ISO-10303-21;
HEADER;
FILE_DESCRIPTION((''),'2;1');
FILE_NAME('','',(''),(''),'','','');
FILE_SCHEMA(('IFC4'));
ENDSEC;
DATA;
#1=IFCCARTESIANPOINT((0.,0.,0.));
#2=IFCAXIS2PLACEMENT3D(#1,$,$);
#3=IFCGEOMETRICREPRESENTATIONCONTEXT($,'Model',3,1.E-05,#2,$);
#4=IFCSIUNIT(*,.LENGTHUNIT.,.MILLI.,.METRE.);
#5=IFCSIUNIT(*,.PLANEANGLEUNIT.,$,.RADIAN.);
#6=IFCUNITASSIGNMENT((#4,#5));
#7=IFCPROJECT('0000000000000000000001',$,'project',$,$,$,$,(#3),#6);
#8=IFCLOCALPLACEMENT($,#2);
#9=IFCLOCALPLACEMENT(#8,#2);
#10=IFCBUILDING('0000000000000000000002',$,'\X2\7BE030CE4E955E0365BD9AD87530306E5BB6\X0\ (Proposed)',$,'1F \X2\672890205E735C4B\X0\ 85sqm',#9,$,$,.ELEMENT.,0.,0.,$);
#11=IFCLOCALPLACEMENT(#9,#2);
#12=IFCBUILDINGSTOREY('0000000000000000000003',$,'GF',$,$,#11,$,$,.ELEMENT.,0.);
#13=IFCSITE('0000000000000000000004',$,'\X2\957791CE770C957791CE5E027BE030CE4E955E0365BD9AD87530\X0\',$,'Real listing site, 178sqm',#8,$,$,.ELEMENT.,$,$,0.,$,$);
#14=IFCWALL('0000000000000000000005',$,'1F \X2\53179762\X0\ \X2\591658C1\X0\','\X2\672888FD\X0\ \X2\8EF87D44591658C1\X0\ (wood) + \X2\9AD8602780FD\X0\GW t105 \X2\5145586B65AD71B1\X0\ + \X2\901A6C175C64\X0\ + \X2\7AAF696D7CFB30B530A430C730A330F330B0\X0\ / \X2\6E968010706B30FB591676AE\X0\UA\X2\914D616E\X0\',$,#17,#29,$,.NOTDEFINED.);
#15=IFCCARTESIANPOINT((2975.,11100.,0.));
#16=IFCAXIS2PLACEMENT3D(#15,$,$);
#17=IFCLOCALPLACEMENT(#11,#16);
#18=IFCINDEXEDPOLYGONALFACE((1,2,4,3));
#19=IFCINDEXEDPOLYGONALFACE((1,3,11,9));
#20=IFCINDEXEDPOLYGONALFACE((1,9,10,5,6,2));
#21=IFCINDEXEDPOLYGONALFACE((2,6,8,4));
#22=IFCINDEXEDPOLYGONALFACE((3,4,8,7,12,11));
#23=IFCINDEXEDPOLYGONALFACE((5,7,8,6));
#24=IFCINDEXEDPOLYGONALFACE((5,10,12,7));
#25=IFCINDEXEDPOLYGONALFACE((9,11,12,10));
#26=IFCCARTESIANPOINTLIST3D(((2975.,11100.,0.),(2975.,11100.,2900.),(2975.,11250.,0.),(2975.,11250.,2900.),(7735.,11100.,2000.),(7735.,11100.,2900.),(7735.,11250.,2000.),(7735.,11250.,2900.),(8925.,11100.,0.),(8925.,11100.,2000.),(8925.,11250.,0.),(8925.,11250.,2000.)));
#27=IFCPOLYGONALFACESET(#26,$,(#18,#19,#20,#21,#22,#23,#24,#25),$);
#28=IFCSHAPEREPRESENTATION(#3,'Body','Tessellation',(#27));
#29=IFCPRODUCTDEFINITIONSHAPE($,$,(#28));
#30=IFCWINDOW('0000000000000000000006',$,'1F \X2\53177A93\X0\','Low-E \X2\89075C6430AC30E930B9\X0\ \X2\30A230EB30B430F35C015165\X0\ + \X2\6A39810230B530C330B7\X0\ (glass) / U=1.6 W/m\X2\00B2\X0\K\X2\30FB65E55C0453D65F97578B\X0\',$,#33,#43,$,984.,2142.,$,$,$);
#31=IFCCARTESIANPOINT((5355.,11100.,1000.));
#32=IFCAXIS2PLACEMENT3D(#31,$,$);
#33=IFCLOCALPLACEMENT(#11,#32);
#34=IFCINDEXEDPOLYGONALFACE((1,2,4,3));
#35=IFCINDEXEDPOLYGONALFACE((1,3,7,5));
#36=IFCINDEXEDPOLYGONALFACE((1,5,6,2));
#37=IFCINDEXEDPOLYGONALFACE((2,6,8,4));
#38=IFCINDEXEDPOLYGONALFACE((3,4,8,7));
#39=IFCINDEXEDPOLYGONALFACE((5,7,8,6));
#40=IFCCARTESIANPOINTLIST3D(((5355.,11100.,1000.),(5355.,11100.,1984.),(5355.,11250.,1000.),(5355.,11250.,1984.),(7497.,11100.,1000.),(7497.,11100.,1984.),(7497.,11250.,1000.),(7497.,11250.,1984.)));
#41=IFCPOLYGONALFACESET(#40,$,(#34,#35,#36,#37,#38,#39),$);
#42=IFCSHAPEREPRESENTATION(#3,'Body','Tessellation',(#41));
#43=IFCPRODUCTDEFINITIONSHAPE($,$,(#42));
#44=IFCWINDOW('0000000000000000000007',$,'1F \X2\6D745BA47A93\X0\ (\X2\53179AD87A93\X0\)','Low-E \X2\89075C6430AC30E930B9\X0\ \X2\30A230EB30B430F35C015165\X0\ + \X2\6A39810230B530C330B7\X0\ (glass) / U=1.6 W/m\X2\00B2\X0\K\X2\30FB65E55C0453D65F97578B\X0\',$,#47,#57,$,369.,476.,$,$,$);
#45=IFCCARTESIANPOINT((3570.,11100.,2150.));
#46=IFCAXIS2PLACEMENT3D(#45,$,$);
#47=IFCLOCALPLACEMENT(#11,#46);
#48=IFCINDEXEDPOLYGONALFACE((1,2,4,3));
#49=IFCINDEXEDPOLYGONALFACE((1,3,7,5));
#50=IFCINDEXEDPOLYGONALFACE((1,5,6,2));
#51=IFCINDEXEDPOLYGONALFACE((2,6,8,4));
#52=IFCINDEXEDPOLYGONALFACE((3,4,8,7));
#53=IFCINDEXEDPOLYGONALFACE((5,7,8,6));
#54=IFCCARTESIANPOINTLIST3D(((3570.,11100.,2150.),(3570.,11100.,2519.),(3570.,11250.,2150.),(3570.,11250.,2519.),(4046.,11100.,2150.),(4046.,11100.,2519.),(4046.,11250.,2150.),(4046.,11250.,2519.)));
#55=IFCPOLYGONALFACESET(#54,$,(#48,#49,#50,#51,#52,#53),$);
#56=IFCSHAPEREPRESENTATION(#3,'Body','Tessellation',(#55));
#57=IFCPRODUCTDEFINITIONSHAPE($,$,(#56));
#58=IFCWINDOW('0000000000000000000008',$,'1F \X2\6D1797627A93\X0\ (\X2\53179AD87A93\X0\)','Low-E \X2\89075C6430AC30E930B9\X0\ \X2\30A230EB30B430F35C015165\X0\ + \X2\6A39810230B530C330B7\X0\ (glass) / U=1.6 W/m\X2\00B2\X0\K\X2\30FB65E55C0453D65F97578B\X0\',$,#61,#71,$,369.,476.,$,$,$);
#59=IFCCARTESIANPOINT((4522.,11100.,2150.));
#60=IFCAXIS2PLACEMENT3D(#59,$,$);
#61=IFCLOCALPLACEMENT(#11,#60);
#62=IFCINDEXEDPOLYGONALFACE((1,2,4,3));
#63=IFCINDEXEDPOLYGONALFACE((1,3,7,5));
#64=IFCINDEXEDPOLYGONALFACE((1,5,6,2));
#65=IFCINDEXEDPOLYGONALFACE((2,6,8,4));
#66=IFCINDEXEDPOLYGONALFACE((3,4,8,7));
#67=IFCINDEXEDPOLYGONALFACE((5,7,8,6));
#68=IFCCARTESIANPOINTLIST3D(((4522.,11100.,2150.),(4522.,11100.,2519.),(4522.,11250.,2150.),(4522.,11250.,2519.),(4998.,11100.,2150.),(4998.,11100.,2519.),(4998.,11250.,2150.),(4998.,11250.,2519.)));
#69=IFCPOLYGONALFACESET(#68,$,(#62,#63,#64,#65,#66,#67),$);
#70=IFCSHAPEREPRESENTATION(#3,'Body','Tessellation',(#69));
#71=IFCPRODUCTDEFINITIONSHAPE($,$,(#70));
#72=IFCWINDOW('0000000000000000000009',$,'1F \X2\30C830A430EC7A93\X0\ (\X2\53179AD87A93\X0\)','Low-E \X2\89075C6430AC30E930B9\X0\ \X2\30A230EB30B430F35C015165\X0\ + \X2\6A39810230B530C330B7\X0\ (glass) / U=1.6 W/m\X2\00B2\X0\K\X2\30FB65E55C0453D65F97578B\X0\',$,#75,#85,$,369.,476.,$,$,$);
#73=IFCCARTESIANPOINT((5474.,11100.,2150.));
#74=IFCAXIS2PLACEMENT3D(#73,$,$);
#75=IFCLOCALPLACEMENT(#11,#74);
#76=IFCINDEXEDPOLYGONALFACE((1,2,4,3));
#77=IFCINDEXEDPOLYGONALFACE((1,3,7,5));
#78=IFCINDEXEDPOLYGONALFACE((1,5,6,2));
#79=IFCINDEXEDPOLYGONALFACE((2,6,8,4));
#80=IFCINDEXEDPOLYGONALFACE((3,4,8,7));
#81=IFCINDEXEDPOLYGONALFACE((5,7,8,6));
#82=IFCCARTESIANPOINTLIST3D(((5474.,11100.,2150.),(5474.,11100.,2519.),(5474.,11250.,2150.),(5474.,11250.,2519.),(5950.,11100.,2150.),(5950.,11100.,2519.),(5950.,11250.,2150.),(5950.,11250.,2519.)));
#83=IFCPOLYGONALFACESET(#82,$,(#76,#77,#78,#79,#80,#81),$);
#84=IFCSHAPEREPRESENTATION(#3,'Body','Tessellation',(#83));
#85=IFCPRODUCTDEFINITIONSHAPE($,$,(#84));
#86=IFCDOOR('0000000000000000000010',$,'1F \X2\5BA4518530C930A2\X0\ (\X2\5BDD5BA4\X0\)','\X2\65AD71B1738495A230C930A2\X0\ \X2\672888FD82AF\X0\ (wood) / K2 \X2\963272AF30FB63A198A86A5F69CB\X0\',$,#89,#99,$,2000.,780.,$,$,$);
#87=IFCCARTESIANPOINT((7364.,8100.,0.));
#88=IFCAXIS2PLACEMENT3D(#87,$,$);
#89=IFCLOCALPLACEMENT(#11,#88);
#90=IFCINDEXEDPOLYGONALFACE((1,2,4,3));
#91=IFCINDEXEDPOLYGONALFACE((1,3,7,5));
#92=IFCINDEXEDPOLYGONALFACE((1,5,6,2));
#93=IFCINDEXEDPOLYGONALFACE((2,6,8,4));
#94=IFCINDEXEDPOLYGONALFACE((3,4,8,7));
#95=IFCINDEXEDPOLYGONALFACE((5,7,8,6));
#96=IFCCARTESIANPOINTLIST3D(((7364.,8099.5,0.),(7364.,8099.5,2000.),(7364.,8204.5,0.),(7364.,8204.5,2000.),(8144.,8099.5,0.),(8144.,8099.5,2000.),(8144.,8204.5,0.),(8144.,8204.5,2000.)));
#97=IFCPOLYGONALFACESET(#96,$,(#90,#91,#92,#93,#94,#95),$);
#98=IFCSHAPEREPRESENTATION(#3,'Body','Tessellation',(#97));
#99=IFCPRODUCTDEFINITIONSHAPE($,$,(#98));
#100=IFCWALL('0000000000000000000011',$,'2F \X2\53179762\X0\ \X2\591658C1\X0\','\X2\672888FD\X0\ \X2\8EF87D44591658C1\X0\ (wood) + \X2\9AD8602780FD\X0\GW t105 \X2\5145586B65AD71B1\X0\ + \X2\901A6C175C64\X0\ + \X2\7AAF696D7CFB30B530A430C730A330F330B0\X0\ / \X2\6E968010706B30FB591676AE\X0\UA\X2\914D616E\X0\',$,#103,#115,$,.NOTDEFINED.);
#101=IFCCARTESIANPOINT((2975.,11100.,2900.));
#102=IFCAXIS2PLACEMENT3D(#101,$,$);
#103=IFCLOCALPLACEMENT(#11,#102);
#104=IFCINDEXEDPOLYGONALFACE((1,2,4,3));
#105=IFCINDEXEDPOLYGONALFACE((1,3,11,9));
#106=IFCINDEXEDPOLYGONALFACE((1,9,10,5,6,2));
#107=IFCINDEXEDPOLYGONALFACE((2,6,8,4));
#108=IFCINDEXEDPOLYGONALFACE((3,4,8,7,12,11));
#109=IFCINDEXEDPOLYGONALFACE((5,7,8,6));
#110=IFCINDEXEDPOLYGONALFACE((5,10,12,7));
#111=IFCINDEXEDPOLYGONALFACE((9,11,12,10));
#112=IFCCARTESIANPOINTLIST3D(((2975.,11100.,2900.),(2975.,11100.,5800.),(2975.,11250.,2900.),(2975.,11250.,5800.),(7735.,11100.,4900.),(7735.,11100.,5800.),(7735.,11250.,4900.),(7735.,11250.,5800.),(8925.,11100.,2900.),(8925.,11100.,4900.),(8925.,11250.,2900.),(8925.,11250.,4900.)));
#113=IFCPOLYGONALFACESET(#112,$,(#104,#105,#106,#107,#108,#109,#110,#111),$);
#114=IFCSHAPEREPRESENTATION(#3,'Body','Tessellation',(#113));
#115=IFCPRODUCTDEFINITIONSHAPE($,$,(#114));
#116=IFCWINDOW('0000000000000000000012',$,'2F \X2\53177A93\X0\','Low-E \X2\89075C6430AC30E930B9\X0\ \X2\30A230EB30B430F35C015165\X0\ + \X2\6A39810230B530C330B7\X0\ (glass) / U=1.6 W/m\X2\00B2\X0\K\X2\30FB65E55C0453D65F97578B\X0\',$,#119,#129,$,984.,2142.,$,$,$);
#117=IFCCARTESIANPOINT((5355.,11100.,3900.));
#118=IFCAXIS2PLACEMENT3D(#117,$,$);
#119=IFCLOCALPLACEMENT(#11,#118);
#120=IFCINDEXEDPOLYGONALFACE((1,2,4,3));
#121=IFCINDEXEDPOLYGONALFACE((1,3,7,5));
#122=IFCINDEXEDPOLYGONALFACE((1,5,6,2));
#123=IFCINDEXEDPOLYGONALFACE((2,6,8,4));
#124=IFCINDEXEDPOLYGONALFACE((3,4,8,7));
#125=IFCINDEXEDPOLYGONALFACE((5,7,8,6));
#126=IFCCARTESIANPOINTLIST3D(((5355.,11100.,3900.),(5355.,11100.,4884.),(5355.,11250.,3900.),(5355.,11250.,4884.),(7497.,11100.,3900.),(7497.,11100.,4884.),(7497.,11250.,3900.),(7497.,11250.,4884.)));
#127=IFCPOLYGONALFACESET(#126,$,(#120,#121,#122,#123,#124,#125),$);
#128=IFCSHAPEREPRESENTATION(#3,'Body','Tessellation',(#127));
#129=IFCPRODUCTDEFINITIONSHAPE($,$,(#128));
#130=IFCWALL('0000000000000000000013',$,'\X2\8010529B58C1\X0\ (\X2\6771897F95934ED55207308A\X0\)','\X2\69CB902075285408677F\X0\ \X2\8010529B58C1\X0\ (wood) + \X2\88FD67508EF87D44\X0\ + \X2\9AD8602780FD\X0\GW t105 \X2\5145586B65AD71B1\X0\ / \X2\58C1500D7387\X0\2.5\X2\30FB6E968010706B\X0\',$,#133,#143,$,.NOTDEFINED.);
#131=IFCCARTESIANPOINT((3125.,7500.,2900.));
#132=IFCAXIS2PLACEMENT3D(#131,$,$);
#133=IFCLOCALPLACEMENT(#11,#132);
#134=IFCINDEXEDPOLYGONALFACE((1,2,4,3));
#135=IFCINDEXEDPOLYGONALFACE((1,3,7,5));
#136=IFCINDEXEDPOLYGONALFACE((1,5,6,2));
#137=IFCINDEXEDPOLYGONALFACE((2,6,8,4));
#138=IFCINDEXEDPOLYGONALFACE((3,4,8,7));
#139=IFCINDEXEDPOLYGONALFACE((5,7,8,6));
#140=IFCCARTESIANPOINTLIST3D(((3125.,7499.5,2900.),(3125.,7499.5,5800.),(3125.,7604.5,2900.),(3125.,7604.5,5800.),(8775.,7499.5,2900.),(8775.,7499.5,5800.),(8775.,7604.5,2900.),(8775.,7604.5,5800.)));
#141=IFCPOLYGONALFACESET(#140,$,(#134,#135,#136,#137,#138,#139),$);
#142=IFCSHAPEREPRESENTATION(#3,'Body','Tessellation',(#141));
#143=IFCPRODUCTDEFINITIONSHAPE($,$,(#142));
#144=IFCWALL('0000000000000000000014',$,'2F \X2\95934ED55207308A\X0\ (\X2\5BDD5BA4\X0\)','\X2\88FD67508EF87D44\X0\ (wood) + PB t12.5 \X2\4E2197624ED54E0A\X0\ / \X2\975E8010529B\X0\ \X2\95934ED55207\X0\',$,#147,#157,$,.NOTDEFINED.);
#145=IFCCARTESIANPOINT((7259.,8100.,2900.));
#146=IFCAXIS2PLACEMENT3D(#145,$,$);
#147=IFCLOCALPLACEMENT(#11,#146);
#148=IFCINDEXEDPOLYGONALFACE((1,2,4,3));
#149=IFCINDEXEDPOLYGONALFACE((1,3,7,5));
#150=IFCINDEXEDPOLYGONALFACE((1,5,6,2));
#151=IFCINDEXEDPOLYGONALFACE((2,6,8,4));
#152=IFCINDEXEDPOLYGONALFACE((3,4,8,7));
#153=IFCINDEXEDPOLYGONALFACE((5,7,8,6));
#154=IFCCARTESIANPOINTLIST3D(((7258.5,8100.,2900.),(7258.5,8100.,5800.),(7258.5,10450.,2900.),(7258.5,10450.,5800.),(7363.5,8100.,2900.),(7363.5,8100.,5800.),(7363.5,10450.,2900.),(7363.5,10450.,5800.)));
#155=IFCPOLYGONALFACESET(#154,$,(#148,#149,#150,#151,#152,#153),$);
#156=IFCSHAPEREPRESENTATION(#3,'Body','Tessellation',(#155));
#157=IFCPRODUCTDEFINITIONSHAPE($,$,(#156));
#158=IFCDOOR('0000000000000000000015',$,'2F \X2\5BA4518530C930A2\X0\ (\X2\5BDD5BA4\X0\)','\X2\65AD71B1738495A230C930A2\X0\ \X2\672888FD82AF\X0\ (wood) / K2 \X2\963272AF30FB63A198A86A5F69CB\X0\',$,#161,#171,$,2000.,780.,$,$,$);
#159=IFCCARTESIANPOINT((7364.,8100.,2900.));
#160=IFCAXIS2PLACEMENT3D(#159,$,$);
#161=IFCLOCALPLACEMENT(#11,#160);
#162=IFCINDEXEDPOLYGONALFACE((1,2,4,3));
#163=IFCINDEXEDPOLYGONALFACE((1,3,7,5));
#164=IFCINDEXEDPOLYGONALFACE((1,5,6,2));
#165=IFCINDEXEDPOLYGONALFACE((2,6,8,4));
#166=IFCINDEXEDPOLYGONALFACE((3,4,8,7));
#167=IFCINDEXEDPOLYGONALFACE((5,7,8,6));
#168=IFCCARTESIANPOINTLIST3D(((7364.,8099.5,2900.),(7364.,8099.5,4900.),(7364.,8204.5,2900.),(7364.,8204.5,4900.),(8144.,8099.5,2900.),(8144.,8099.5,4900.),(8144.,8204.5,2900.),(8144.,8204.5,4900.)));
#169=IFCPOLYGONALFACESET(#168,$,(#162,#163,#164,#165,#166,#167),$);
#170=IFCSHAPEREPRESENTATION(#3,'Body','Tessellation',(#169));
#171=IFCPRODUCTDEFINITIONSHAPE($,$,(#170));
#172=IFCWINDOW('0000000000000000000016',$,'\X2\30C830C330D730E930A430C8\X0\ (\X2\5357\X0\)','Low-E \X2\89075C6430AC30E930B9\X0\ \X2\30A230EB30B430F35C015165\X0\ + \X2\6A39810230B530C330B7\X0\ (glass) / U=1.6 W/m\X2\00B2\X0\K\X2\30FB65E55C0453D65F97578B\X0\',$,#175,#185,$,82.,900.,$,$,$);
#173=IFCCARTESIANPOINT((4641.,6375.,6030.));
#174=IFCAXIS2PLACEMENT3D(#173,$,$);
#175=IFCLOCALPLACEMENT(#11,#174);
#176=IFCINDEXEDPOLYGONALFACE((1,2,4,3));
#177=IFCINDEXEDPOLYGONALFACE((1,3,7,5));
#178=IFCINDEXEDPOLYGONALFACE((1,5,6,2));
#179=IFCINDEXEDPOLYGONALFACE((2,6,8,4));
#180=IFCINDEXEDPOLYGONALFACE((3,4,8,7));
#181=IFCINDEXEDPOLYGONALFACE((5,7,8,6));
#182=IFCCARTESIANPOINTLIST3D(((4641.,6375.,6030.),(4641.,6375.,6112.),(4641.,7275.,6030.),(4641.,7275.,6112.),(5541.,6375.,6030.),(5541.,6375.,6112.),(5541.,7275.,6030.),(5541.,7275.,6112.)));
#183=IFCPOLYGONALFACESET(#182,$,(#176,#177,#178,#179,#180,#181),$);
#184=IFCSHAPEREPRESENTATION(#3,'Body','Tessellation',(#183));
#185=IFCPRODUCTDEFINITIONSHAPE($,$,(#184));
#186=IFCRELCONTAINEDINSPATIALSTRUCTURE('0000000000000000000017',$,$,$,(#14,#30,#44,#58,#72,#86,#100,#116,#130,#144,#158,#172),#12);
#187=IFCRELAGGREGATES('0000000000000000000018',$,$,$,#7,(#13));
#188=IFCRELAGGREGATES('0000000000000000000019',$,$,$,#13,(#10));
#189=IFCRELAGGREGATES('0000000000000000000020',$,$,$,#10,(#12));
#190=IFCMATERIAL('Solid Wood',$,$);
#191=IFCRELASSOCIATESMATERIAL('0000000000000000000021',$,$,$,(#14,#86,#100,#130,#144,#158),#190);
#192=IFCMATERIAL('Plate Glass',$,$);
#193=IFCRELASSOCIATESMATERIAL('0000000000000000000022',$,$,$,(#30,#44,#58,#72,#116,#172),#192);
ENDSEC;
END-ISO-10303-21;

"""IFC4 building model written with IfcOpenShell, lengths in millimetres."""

from ifc_helpers import new_model, si_unit, frame, frame_2d, origin, place, context, project, spatial, rectangle, extrude, material, element, fill, save


model = new_model("IFC4")

# Units and contexts
model_context = context("Model", 3, precision=1e-05, world=origin())
ifc_project = project(units=[si_unit("LENGTHUNIT", "METRE", prefix="MILLI"), si_unit("PLANEANGLEUNIT", "RADIAN")], contexts=[model_context])

# Site, building, storey
site_placement = place(None, origin())
site = spatial("IfcSite", under=ifc_project, at=site_placement, Name="長野県長野市篠ノ井布施高田", ObjectType="Real listing site, 178sqm", CompositionType="ELEMENT", RefElevation=0.0)
building_placement = place(site_placement, origin())
building = spatial("IfcBuilding", under=site, at=building_placement, Name="篠ノ井布施高田の家 (Proposed)", ObjectType="1F 木造平屋 85sqm", CompositionType="ELEMENT", ElevationOfRefHeight=0.0, ElevationOfTerrain=0.0)
storey_placement = place(building_placement, origin())
storey = spatial("IfcBuildingStorey", under=building, at=storey_placement, Name="GF", CompositionType="ELEMENT", Elevation=0.0)

# Wall, openings, windows
ifc_material_1 = material(Name="Solid Wood")
wall_1_placement = place(storey_placement, frame((2975.0, 11100.0, 0.0)))
wall_1 = element("IfcWall", 1, at=wall_1_placement, inside=storey, material=ifc_material_1, Name="1F 北面 外壁", Description="木製 軸組外壁 (wood) + 高性能GW t105 充填断熱 + 通気層 + 窯業系サイディング / 準耐火・外皮UA配慮", PredefinedType="NOTDEFINED", context=model_context, shape_type="SweptSolid", body=[
    extrude(rectangle(XDim=5950.0, YDim=150.0, at=frame_2d((2975.0, 75.0))), frame((2975.0, 11100.0, 0.0)), (0.0, 0.0, 1.0), 2900.0),
])
opening_1_placement = place(storey_placement, frame((5355.0, 11100.0, 1000.0)))
opening_1 = element("IfcOpeningElement", 2, at=opening_1_placement, cuts=wall_1, PredefinedType="NOTDEFINED", context=model_context, shape_type="SweptSolid", body=[
    extrude(rectangle(XDim=2142.0, YDim=150.0, at=frame_2d((1071.0, 75.0))), frame((5355.0, 11100.0, 1000.0)), (0.0, 0.0, 1.0), 984.0),
])
opening_2_placement = place(storey_placement, frame((3570.0, 11100.0, 2150.0)))
opening_2 = element("IfcOpeningElement", 3, at=opening_2_placement, cuts=wall_1, PredefinedType="NOTDEFINED", context=model_context, shape_type="SweptSolid", body=[
    extrude(rectangle(XDim=476.0, YDim=150.0, at=frame_2d((238.0, 75.0))), frame((3570.0, 11100.0, 2150.0)), (0.0, 0.0, 1.0), 369.0),
])
opening_3_placement = place(storey_placement, frame((4522.0, 11100.0, 2150.0)))
opening_3 = element("IfcOpeningElement", 4, at=opening_3_placement, cuts=wall_1, PredefinedType="NOTDEFINED", context=model_context, shape_type="SweptSolid", body=[
    extrude(rectangle(XDim=476.0, YDim=150.0, at=frame_2d((238.0, 75.0))), frame((4522.0, 11100.0, 2150.0)), (0.0, 0.0, 1.0), 369.0),
])
opening_4_placement = place(storey_placement, frame((5474.0, 11100.0, 2150.0)))
opening_4 = element("IfcOpeningElement", 5, at=opening_4_placement, cuts=wall_1, PredefinedType="NOTDEFINED", context=model_context, shape_type="SweptSolid", body=[
    extrude(rectangle(XDim=476.0, YDim=150.0, at=frame_2d((238.0, 75.0))), frame((5474.0, 11100.0, 2150.0)), (0.0, 0.0, 1.0), 369.0),
])
ifc_material_2 = material(Name="Plate Glass")
window_1_placement = place(storey_placement, frame((5355.0, 11100.0, 1000.0)))
window_1 = element("IfcWindow", 6, at=window_1_placement, inside=storey, material=ifc_material_2, Name="1F 北窓", Description="Low-E 複層ガラス アルゴン封入 + 樹脂サッシ (glass) / U=1.6 W/m²K・日射取得型", OverallHeight=984.0, OverallWidth=2142.0, context=model_context, shape_type="SweptSolid", body=[
    extrude(rectangle(XDim=2142.0, YDim=150.0, at=frame_2d((1071.0, 75.0))), frame((5355.0, 11100.0, 1000.0)), (0.0, 0.0, 1.0), 984.0),
])
fill(opening_1, window_1)
window_2_placement = place(storey_placement, frame((3570.0, 11100.0, 2150.0)))
window_2 = element("IfcWindow", 7, at=window_2_placement, inside=storey, material=ifc_material_2, Name="1F 浴室窓 (北高窓)", Description="Low-E 複層ガラス アルゴン封入 + 樹脂サッシ (glass) / U=1.6 W/m²K・日射取得型", OverallHeight=369.0, OverallWidth=476.0, context=model_context, shape_type="SweptSolid", body=[
    extrude(rectangle(XDim=476.0, YDim=150.0, at=frame_2d((238.0, 75.0))), frame((3570.0, 11100.0, 2150.0)), (0.0, 0.0, 1.0), 369.0),
])
fill(opening_2, window_2)
window_3_placement = place(storey_placement, frame((4522.0, 11100.0, 2150.0)))
window_3 = element("IfcWindow", 8, at=window_3_placement, inside=storey, material=ifc_material_2, Name="1F 洗面窓 (北高窓)", Description="Low-E 複層ガラス アルゴン封入 + 樹脂サッシ (glass) / U=1.6 W/m²K・日射取得型", OverallHeight=369.0, OverallWidth=476.0, context=model_context, shape_type="SweptSolid", body=[
    extrude(rectangle(XDim=476.0, YDim=150.0, at=frame_2d((238.0, 75.0))), frame((4522.0, 11100.0, 2150.0)), (0.0, 0.0, 1.0), 369.0),
])
fill(opening_3, window_3)
window_4_placement = place(storey_placement, frame((5474.0, 11100.0, 2150.0)))
window_4 = element("IfcWindow", 9, at=window_4_placement, inside=storey, material=ifc_material_2, Name="1F トイレ窓 (北高窓)", Description="Low-E 複層ガラス アルゴン封入 + 樹脂サッシ (glass) / U=1.6 W/m²K・日射取得型", OverallHeight=369.0, OverallWidth=476.0, context=model_context, shape_type="SweptSolid", body=[
    extrude(rectangle(XDim=476.0, YDim=150.0, at=frame_2d((238.0, 75.0))), frame((5474.0, 11100.0, 2150.0)), (0.0, 0.0, 1.0), 369.0),
])
fill(opening_4, window_4)

# Door
door_1_placement = place(storey_placement, frame((7364.0, 8100.0, 0.0)))
element("IfcDoor", 10, at=door_1_placement, inside=storey, material=ifc_material_1, Name="1F 室内ドア (寝室)", Description="断熱玄関ドア 木製芯 (wood) / K2 防犯・採風機構", OverallHeight=2000.0, OverallWidth=780.0, context=model_context, shape_type="SweptSolid", body=[
    extrude(rectangle(XDim=780.0, YDim=105.0, at=frame_2d((390.0, 52.0))), frame((7364.0, 8100.0, 0.0)), (0.0, 0.0, 1.0), 2000.0),
])

# Wall, opening, window
wall_2_placement = place(storey_placement, frame((2975.0, 11100.0, 2900.0)))
wall_2 = element("IfcWall", 11, at=wall_2_placement, inside=storey, material=ifc_material_1, Name="2F 北面 外壁", Description="木製 軸組外壁 (wood) + 高性能GW t105 充填断熱 + 通気層 + 窯業系サイディング / 準耐火・外皮UA配慮", PredefinedType="NOTDEFINED", context=model_context, shape_type="SweptSolid", body=[
    extrude(rectangle(XDim=5950.0, YDim=150.0, at=frame_2d((2975.0, 75.0))), frame((2975.0, 11100.0, 2900.0)), (0.0, 0.0, 1.0), 2900.0),
])
opening_5_placement = place(storey_placement, frame((5355.0, 11100.0, 3900.0)))
opening_5 = element("IfcOpeningElement", 12, at=opening_5_placement, cuts=wall_2, PredefinedType="NOTDEFINED", context=model_context, shape_type="SweptSolid", body=[
    extrude(rectangle(XDim=2142.0, YDim=150.0, at=frame_2d((1071.0, 75.0))), frame((5355.0, 11100.0, 3900.0)), (0.0, 0.0, 1.0), 984.0),
])
window_5_placement = place(storey_placement, frame((5355.0, 11100.0, 3900.0)))
window_5 = element("IfcWindow", 13, at=window_5_placement, inside=storey, material=ifc_material_2, Name="2F 北窓", Description="Low-E 複層ガラス アルゴン封入 + 樹脂サッシ (glass) / U=1.6 W/m²K・日射取得型", OverallHeight=984.0, OverallWidth=2142.0, context=model_context, shape_type="SweptSolid", body=[
    extrude(rectangle(XDim=2142.0, YDim=150.0, at=frame_2d((1071.0, 75.0))), frame((5355.0, 11100.0, 3900.0)), (0.0, 0.0, 1.0), 984.0),
])
fill(opening_5, window_5)

# Walls
wall_3_placement = place(storey_placement, frame((3125.0, 7500.0, 2900.0)))
element("IfcWall", 14, at=wall_3_placement, inside=storey, material=ifc_material_1, Name="耐力壁 (東西間仕切り)", Description="構造用合板 耐力壁 (wood) + 製材軸組 + 高性能GW t105 充填断熱 / 壁倍率2.5・準耐火", PredefinedType="NOTDEFINED", context=model_context, shape_type="SweptSolid", body=[
    extrude(rectangle(XDim=5650.0, YDim=105.0, at=frame_2d((2825.0, 52.0))), frame((3125.0, 7500.0, 2900.0)), (0.0, 0.0, 1.0), 2900.0),
])
wall_4_placement = place(storey_placement, frame((7259.0, 8100.0, 2900.0)))
element("IfcWall", 15, at=wall_4_placement, inside=storey, material=ifc_material_1, Name="2F 間仕切り (寝室)", Description="製材軸組 (wood) + PB t12.5 両面仕上 / 非耐力 間仕切", PredefinedType="NOTDEFINED", context=model_context, shape_type="SweptSolid", body=[
    extrude(rectangle(XDim=105.0, YDim=2350.0, at=frame_2d((52.0, 1175.0))), frame((7259.0, 8100.0, 2900.0)), (0.0, 0.0, 1.0), 2900.0),
])

# Door
door_2_placement = place(storey_placement, frame((7364.0, 8100.0, 2900.0)))
element("IfcDoor", 16, at=door_2_placement, inside=storey, material=ifc_material_1, Name="2F 室内ドア (寝室)", Description="断熱玄関ドア 木製芯 (wood) / K2 防犯・採風機構", OverallHeight=2000.0, OverallWidth=780.0, context=model_context, shape_type="SweptSolid", body=[
    extrude(rectangle(XDim=780.0, YDim=105.0, at=frame_2d((390.0, 52.0))), frame((7364.0, 8100.0, 2900.0)), (0.0, 0.0, 1.0), 2000.0),
])

# Window
window_6_placement = place(storey_placement, frame((4641.0, 6375.0, 6030.0)))
element("IfcWindow", 17, at=window_6_placement, inside=storey, material=ifc_material_2, Name="トップライト (南)", Description="Low-E 複層ガラス アルゴン封入 + 樹脂サッシ (glass) / U=1.6 W/m²K・日射取得型", OverallHeight=82.0, OverallWidth=900.0, context=model_context, shape_type="SweptSolid", body=[
    extrude(rectangle(XDim=900.0, YDim=900.0, at=frame_2d((450.0, 450.0))), frame((4641.0, 6375.0, 6030.0)), (0.0, 0.0, 1.0), 82.0),
])

save(model, "model.ifc")
